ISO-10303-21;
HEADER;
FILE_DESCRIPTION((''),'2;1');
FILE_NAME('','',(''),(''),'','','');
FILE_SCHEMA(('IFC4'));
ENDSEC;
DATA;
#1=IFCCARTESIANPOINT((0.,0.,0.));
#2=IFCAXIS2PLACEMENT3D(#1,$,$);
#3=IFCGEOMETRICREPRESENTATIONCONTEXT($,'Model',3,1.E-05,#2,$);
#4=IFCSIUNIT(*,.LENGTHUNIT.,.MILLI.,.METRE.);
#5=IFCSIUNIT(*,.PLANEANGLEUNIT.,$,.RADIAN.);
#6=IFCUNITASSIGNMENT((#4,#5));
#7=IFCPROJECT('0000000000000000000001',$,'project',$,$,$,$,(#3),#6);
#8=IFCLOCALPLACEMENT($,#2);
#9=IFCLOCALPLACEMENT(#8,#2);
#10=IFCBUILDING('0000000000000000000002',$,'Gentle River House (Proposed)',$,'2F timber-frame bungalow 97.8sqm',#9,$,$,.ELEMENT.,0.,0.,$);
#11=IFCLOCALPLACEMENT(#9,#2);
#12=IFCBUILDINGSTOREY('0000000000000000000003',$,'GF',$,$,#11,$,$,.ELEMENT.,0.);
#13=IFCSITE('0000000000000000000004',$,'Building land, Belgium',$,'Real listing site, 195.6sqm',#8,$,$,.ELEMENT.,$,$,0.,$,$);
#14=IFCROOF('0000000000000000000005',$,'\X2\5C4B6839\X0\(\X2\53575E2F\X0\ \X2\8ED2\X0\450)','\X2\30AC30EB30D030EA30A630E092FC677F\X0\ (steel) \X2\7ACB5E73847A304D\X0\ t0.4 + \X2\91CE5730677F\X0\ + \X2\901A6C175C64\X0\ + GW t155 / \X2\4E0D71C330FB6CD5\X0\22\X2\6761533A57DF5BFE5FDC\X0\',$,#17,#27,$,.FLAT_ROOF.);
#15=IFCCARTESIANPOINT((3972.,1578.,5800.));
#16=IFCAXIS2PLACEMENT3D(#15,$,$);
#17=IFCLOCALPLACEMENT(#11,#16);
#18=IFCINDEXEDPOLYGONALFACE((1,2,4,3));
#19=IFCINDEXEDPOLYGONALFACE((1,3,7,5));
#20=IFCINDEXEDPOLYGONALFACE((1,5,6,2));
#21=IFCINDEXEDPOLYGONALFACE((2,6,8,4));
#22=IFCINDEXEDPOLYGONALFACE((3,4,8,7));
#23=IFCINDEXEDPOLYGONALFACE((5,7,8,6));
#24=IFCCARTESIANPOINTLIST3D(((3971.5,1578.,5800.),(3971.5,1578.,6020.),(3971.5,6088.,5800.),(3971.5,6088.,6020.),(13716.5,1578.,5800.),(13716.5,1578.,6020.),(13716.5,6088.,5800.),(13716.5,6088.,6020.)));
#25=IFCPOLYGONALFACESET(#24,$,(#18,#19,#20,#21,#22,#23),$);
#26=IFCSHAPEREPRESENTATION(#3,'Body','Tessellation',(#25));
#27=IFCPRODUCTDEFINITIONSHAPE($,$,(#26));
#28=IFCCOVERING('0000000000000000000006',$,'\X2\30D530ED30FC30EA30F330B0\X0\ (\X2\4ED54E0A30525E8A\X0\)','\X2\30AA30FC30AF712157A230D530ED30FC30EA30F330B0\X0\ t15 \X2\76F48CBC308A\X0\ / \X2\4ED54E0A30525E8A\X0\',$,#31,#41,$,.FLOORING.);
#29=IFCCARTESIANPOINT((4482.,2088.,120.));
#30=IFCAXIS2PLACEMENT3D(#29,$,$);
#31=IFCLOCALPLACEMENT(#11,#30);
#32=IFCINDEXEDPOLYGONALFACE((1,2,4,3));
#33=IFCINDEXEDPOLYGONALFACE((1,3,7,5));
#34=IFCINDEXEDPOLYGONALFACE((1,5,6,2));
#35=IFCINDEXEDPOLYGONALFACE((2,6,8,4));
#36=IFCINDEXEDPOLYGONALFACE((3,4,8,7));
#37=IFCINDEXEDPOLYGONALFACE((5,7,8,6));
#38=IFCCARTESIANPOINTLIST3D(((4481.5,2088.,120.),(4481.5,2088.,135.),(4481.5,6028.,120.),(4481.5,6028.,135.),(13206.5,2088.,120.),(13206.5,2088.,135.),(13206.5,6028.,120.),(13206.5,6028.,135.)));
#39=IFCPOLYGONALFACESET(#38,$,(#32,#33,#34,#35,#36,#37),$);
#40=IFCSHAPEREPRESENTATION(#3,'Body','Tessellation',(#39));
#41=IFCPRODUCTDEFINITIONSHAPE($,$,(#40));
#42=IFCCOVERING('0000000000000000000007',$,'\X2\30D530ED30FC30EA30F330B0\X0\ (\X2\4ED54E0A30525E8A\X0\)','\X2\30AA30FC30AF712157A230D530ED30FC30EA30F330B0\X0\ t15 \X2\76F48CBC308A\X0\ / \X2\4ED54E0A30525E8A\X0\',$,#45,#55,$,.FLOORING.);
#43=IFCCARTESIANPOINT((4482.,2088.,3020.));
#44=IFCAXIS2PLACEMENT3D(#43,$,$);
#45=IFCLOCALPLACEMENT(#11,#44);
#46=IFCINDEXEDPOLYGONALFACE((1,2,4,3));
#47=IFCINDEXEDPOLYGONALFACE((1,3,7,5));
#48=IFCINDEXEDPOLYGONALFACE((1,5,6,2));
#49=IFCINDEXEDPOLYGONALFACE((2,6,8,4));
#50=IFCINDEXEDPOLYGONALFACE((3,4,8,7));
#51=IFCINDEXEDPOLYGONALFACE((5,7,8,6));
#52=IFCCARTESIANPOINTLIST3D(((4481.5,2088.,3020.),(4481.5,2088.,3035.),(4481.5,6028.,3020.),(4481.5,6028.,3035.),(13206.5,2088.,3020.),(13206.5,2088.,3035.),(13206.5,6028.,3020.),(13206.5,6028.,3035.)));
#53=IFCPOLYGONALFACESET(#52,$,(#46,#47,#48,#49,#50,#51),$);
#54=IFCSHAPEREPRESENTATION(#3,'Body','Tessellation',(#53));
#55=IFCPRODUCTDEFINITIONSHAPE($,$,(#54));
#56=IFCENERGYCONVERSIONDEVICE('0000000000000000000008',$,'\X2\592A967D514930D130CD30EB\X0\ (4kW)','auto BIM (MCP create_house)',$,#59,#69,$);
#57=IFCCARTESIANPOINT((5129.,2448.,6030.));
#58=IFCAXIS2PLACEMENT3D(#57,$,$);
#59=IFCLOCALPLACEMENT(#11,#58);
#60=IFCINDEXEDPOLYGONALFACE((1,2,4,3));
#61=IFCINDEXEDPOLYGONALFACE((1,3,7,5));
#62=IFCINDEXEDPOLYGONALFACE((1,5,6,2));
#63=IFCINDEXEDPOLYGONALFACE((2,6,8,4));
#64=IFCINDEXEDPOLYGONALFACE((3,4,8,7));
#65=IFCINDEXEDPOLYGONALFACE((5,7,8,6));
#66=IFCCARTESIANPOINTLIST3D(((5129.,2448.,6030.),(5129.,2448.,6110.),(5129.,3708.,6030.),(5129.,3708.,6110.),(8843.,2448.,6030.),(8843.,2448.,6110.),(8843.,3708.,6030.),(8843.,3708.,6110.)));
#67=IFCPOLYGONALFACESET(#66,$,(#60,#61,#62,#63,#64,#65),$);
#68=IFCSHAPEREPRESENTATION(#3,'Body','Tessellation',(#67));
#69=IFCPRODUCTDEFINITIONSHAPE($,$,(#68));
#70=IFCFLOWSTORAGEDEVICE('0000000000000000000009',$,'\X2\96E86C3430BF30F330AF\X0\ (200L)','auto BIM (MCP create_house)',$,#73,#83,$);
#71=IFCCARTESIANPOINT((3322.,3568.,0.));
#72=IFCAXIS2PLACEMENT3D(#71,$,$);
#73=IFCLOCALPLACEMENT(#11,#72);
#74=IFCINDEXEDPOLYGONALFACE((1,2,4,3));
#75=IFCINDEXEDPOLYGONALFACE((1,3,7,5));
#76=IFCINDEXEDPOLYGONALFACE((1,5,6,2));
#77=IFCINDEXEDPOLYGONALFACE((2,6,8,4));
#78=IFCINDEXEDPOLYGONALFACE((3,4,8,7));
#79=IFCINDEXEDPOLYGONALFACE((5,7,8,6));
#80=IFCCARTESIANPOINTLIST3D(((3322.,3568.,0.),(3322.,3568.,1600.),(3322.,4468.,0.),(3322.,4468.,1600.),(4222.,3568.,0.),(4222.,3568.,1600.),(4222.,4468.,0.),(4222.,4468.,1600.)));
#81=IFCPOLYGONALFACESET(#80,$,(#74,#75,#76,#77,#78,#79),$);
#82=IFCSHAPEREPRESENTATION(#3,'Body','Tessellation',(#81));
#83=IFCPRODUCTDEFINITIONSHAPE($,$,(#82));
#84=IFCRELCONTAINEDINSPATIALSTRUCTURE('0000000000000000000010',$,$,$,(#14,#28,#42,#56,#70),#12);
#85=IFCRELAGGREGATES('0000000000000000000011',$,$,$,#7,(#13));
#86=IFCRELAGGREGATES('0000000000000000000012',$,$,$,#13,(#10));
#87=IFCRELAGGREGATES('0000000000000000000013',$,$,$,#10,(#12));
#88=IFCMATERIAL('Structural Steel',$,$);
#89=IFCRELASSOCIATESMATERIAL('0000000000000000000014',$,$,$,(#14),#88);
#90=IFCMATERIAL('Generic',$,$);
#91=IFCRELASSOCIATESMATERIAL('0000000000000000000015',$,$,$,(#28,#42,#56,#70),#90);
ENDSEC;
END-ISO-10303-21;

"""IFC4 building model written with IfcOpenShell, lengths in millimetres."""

from ifc_helpers import new_model, si_unit, frame, frame_2d, origin, place, context, project, spatial, rectangle, extrude, material, element, save


model = new_model("IFC4")

# Units and contexts
model_context = context("Model", 3, precision=1e-05, world=origin())
ifc_project = project(units=[si_unit("LENGTHUNIT", "METRE", prefix="MILLI"), si_unit("PLANEANGLEUNIT", "RADIAN")], contexts=[model_context])

# Site, building, storey
site_placement = place(None, origin())
site = spatial("IfcSite", under=ifc_project, at=site_placement, Name="Building land, Belgium", ObjectType="Real listing site, 195.6sqm", CompositionType="ELEMENT", RefElevation=0.0)
building_placement = place(site_placement, origin())
building = spatial("IfcBuilding", under=site, at=building_placement, Name="Gentle River House (Proposed)", ObjectType="2F timber-frame bungalow 97.8sqm", CompositionType="ELEMENT", ElevationOfRefHeight=0.0, ElevationOfTerrain=0.0)
storey_placement = place(building_placement, origin())
storey = spatial("IfcBuildingStorey", under=building, at=storey_placement, Name="GF", CompositionType="ELEMENT", Elevation=0.0)

# Roof
ifc_material_1 = material(Name="Structural Steel")
for number, where, name in (
    (1, (3972.0, 1578.0, 5800.0), "屋根(南帯 軒450)"),
):
    element("IfcRoof", number, at=place(storey_placement, frame(where)), inside=storey, material=ifc_material_1, Name=name, Description="ガルバリウム鋼板 (steel) 立平葺き t0.4 + 野地板 + 通気層 + GW t155 / 不燃・法22条区域対応", PredefinedType="FLAT_ROOF", context=model_context, shape_type="SweptSolid", body=[
        extrude(rectangle(XDim=9745.0, YDim=4510.0, at=frame_2d((4872.0, 2255.0))), frame((3972.0, 1578.0, 5800.0)), (0.0, 0.0, 1.0), 220.0),
    ])

# Coverings
ifc_material_2 = material(Name="Generic")
covering_1_placement = place(storey_placement, frame((4482.0, 2088.0, 120.0)))
element("IfcCovering", 2, at=covering_1_placement, inside=storey, material=ifc_material_2, Name="フローリング (仕上げ床)", Description="オーク無垢フローリング t15 直貼り / 仕上げ床", PredefinedType="FLOORING", context=model_context, shape_type="SweptSolid", body=[
    extrude(rectangle(XDim=8725.0, YDim=3940.0, at=frame_2d((4362.0, 1970.0))), frame((4482.0, 2088.0, 120.0)), (0.0, 0.0, 1.0), 15.0),
])
covering_2_placement = place(storey_placement, frame((4482.0, 2088.0, 3020.0)))
element("IfcCovering", 3, at=covering_2_placement, inside=storey, material=ifc_material_2, Name="フローリング (仕上げ床)", Description="オーク無垢フローリング t15 直貼り / 仕上げ床", PredefinedType="FLOORING", context=model_context, shape_type="SweptSolid", body=[
    extrude(rectangle(XDim=8725.0, YDim=3940.0, at=frame_2d((4362.0, 1970.0))), frame((4482.0, 2088.0, 3020.0)), (0.0, 0.0, 1.0), 15.0),
])

# Energy conversion device
energy_conversion_device_placement = place(storey_placement, frame((5129.0, 2448.0, 6030.0)))
element("IfcEnergyConversionDevice", 4, at=energy_conversion_device_placement, inside=storey, material=ifc_material_2, Name="太陽光パネル (4kW)", Description="auto BIM (MCP create_house)", context=model_context, shape_type="SweptSolid", body=[
    extrude(rectangle(XDim=3714.0, YDim=1260.0, at=frame_2d((1857.0, 630.0))), frame((5129.0, 2448.0, 6030.0)), (0.0, 0.0, 1.0), 80.0),
])

# Flow storage device
flow_storage_device_placement = place(storey_placement, frame((3322.0, 3568.0, 0.0)))
element("IfcFlowStorageDevice", 5, at=flow_storage_device_placement, inside=storey, material=ifc_material_2, Name="雨水タンク (200L)", Description="auto BIM (MCP create_house)", context=model_context, shape_type="SweptSolid", body=[
    extrude(rectangle(XDim=900.0, YDim=900.0, at=frame_2d((450.0, 450.0))), frame((3322.0, 3568.0, 0.0)), (0.0, 0.0, 1.0), 1600.0),
])

save(model, "model.ifc")
